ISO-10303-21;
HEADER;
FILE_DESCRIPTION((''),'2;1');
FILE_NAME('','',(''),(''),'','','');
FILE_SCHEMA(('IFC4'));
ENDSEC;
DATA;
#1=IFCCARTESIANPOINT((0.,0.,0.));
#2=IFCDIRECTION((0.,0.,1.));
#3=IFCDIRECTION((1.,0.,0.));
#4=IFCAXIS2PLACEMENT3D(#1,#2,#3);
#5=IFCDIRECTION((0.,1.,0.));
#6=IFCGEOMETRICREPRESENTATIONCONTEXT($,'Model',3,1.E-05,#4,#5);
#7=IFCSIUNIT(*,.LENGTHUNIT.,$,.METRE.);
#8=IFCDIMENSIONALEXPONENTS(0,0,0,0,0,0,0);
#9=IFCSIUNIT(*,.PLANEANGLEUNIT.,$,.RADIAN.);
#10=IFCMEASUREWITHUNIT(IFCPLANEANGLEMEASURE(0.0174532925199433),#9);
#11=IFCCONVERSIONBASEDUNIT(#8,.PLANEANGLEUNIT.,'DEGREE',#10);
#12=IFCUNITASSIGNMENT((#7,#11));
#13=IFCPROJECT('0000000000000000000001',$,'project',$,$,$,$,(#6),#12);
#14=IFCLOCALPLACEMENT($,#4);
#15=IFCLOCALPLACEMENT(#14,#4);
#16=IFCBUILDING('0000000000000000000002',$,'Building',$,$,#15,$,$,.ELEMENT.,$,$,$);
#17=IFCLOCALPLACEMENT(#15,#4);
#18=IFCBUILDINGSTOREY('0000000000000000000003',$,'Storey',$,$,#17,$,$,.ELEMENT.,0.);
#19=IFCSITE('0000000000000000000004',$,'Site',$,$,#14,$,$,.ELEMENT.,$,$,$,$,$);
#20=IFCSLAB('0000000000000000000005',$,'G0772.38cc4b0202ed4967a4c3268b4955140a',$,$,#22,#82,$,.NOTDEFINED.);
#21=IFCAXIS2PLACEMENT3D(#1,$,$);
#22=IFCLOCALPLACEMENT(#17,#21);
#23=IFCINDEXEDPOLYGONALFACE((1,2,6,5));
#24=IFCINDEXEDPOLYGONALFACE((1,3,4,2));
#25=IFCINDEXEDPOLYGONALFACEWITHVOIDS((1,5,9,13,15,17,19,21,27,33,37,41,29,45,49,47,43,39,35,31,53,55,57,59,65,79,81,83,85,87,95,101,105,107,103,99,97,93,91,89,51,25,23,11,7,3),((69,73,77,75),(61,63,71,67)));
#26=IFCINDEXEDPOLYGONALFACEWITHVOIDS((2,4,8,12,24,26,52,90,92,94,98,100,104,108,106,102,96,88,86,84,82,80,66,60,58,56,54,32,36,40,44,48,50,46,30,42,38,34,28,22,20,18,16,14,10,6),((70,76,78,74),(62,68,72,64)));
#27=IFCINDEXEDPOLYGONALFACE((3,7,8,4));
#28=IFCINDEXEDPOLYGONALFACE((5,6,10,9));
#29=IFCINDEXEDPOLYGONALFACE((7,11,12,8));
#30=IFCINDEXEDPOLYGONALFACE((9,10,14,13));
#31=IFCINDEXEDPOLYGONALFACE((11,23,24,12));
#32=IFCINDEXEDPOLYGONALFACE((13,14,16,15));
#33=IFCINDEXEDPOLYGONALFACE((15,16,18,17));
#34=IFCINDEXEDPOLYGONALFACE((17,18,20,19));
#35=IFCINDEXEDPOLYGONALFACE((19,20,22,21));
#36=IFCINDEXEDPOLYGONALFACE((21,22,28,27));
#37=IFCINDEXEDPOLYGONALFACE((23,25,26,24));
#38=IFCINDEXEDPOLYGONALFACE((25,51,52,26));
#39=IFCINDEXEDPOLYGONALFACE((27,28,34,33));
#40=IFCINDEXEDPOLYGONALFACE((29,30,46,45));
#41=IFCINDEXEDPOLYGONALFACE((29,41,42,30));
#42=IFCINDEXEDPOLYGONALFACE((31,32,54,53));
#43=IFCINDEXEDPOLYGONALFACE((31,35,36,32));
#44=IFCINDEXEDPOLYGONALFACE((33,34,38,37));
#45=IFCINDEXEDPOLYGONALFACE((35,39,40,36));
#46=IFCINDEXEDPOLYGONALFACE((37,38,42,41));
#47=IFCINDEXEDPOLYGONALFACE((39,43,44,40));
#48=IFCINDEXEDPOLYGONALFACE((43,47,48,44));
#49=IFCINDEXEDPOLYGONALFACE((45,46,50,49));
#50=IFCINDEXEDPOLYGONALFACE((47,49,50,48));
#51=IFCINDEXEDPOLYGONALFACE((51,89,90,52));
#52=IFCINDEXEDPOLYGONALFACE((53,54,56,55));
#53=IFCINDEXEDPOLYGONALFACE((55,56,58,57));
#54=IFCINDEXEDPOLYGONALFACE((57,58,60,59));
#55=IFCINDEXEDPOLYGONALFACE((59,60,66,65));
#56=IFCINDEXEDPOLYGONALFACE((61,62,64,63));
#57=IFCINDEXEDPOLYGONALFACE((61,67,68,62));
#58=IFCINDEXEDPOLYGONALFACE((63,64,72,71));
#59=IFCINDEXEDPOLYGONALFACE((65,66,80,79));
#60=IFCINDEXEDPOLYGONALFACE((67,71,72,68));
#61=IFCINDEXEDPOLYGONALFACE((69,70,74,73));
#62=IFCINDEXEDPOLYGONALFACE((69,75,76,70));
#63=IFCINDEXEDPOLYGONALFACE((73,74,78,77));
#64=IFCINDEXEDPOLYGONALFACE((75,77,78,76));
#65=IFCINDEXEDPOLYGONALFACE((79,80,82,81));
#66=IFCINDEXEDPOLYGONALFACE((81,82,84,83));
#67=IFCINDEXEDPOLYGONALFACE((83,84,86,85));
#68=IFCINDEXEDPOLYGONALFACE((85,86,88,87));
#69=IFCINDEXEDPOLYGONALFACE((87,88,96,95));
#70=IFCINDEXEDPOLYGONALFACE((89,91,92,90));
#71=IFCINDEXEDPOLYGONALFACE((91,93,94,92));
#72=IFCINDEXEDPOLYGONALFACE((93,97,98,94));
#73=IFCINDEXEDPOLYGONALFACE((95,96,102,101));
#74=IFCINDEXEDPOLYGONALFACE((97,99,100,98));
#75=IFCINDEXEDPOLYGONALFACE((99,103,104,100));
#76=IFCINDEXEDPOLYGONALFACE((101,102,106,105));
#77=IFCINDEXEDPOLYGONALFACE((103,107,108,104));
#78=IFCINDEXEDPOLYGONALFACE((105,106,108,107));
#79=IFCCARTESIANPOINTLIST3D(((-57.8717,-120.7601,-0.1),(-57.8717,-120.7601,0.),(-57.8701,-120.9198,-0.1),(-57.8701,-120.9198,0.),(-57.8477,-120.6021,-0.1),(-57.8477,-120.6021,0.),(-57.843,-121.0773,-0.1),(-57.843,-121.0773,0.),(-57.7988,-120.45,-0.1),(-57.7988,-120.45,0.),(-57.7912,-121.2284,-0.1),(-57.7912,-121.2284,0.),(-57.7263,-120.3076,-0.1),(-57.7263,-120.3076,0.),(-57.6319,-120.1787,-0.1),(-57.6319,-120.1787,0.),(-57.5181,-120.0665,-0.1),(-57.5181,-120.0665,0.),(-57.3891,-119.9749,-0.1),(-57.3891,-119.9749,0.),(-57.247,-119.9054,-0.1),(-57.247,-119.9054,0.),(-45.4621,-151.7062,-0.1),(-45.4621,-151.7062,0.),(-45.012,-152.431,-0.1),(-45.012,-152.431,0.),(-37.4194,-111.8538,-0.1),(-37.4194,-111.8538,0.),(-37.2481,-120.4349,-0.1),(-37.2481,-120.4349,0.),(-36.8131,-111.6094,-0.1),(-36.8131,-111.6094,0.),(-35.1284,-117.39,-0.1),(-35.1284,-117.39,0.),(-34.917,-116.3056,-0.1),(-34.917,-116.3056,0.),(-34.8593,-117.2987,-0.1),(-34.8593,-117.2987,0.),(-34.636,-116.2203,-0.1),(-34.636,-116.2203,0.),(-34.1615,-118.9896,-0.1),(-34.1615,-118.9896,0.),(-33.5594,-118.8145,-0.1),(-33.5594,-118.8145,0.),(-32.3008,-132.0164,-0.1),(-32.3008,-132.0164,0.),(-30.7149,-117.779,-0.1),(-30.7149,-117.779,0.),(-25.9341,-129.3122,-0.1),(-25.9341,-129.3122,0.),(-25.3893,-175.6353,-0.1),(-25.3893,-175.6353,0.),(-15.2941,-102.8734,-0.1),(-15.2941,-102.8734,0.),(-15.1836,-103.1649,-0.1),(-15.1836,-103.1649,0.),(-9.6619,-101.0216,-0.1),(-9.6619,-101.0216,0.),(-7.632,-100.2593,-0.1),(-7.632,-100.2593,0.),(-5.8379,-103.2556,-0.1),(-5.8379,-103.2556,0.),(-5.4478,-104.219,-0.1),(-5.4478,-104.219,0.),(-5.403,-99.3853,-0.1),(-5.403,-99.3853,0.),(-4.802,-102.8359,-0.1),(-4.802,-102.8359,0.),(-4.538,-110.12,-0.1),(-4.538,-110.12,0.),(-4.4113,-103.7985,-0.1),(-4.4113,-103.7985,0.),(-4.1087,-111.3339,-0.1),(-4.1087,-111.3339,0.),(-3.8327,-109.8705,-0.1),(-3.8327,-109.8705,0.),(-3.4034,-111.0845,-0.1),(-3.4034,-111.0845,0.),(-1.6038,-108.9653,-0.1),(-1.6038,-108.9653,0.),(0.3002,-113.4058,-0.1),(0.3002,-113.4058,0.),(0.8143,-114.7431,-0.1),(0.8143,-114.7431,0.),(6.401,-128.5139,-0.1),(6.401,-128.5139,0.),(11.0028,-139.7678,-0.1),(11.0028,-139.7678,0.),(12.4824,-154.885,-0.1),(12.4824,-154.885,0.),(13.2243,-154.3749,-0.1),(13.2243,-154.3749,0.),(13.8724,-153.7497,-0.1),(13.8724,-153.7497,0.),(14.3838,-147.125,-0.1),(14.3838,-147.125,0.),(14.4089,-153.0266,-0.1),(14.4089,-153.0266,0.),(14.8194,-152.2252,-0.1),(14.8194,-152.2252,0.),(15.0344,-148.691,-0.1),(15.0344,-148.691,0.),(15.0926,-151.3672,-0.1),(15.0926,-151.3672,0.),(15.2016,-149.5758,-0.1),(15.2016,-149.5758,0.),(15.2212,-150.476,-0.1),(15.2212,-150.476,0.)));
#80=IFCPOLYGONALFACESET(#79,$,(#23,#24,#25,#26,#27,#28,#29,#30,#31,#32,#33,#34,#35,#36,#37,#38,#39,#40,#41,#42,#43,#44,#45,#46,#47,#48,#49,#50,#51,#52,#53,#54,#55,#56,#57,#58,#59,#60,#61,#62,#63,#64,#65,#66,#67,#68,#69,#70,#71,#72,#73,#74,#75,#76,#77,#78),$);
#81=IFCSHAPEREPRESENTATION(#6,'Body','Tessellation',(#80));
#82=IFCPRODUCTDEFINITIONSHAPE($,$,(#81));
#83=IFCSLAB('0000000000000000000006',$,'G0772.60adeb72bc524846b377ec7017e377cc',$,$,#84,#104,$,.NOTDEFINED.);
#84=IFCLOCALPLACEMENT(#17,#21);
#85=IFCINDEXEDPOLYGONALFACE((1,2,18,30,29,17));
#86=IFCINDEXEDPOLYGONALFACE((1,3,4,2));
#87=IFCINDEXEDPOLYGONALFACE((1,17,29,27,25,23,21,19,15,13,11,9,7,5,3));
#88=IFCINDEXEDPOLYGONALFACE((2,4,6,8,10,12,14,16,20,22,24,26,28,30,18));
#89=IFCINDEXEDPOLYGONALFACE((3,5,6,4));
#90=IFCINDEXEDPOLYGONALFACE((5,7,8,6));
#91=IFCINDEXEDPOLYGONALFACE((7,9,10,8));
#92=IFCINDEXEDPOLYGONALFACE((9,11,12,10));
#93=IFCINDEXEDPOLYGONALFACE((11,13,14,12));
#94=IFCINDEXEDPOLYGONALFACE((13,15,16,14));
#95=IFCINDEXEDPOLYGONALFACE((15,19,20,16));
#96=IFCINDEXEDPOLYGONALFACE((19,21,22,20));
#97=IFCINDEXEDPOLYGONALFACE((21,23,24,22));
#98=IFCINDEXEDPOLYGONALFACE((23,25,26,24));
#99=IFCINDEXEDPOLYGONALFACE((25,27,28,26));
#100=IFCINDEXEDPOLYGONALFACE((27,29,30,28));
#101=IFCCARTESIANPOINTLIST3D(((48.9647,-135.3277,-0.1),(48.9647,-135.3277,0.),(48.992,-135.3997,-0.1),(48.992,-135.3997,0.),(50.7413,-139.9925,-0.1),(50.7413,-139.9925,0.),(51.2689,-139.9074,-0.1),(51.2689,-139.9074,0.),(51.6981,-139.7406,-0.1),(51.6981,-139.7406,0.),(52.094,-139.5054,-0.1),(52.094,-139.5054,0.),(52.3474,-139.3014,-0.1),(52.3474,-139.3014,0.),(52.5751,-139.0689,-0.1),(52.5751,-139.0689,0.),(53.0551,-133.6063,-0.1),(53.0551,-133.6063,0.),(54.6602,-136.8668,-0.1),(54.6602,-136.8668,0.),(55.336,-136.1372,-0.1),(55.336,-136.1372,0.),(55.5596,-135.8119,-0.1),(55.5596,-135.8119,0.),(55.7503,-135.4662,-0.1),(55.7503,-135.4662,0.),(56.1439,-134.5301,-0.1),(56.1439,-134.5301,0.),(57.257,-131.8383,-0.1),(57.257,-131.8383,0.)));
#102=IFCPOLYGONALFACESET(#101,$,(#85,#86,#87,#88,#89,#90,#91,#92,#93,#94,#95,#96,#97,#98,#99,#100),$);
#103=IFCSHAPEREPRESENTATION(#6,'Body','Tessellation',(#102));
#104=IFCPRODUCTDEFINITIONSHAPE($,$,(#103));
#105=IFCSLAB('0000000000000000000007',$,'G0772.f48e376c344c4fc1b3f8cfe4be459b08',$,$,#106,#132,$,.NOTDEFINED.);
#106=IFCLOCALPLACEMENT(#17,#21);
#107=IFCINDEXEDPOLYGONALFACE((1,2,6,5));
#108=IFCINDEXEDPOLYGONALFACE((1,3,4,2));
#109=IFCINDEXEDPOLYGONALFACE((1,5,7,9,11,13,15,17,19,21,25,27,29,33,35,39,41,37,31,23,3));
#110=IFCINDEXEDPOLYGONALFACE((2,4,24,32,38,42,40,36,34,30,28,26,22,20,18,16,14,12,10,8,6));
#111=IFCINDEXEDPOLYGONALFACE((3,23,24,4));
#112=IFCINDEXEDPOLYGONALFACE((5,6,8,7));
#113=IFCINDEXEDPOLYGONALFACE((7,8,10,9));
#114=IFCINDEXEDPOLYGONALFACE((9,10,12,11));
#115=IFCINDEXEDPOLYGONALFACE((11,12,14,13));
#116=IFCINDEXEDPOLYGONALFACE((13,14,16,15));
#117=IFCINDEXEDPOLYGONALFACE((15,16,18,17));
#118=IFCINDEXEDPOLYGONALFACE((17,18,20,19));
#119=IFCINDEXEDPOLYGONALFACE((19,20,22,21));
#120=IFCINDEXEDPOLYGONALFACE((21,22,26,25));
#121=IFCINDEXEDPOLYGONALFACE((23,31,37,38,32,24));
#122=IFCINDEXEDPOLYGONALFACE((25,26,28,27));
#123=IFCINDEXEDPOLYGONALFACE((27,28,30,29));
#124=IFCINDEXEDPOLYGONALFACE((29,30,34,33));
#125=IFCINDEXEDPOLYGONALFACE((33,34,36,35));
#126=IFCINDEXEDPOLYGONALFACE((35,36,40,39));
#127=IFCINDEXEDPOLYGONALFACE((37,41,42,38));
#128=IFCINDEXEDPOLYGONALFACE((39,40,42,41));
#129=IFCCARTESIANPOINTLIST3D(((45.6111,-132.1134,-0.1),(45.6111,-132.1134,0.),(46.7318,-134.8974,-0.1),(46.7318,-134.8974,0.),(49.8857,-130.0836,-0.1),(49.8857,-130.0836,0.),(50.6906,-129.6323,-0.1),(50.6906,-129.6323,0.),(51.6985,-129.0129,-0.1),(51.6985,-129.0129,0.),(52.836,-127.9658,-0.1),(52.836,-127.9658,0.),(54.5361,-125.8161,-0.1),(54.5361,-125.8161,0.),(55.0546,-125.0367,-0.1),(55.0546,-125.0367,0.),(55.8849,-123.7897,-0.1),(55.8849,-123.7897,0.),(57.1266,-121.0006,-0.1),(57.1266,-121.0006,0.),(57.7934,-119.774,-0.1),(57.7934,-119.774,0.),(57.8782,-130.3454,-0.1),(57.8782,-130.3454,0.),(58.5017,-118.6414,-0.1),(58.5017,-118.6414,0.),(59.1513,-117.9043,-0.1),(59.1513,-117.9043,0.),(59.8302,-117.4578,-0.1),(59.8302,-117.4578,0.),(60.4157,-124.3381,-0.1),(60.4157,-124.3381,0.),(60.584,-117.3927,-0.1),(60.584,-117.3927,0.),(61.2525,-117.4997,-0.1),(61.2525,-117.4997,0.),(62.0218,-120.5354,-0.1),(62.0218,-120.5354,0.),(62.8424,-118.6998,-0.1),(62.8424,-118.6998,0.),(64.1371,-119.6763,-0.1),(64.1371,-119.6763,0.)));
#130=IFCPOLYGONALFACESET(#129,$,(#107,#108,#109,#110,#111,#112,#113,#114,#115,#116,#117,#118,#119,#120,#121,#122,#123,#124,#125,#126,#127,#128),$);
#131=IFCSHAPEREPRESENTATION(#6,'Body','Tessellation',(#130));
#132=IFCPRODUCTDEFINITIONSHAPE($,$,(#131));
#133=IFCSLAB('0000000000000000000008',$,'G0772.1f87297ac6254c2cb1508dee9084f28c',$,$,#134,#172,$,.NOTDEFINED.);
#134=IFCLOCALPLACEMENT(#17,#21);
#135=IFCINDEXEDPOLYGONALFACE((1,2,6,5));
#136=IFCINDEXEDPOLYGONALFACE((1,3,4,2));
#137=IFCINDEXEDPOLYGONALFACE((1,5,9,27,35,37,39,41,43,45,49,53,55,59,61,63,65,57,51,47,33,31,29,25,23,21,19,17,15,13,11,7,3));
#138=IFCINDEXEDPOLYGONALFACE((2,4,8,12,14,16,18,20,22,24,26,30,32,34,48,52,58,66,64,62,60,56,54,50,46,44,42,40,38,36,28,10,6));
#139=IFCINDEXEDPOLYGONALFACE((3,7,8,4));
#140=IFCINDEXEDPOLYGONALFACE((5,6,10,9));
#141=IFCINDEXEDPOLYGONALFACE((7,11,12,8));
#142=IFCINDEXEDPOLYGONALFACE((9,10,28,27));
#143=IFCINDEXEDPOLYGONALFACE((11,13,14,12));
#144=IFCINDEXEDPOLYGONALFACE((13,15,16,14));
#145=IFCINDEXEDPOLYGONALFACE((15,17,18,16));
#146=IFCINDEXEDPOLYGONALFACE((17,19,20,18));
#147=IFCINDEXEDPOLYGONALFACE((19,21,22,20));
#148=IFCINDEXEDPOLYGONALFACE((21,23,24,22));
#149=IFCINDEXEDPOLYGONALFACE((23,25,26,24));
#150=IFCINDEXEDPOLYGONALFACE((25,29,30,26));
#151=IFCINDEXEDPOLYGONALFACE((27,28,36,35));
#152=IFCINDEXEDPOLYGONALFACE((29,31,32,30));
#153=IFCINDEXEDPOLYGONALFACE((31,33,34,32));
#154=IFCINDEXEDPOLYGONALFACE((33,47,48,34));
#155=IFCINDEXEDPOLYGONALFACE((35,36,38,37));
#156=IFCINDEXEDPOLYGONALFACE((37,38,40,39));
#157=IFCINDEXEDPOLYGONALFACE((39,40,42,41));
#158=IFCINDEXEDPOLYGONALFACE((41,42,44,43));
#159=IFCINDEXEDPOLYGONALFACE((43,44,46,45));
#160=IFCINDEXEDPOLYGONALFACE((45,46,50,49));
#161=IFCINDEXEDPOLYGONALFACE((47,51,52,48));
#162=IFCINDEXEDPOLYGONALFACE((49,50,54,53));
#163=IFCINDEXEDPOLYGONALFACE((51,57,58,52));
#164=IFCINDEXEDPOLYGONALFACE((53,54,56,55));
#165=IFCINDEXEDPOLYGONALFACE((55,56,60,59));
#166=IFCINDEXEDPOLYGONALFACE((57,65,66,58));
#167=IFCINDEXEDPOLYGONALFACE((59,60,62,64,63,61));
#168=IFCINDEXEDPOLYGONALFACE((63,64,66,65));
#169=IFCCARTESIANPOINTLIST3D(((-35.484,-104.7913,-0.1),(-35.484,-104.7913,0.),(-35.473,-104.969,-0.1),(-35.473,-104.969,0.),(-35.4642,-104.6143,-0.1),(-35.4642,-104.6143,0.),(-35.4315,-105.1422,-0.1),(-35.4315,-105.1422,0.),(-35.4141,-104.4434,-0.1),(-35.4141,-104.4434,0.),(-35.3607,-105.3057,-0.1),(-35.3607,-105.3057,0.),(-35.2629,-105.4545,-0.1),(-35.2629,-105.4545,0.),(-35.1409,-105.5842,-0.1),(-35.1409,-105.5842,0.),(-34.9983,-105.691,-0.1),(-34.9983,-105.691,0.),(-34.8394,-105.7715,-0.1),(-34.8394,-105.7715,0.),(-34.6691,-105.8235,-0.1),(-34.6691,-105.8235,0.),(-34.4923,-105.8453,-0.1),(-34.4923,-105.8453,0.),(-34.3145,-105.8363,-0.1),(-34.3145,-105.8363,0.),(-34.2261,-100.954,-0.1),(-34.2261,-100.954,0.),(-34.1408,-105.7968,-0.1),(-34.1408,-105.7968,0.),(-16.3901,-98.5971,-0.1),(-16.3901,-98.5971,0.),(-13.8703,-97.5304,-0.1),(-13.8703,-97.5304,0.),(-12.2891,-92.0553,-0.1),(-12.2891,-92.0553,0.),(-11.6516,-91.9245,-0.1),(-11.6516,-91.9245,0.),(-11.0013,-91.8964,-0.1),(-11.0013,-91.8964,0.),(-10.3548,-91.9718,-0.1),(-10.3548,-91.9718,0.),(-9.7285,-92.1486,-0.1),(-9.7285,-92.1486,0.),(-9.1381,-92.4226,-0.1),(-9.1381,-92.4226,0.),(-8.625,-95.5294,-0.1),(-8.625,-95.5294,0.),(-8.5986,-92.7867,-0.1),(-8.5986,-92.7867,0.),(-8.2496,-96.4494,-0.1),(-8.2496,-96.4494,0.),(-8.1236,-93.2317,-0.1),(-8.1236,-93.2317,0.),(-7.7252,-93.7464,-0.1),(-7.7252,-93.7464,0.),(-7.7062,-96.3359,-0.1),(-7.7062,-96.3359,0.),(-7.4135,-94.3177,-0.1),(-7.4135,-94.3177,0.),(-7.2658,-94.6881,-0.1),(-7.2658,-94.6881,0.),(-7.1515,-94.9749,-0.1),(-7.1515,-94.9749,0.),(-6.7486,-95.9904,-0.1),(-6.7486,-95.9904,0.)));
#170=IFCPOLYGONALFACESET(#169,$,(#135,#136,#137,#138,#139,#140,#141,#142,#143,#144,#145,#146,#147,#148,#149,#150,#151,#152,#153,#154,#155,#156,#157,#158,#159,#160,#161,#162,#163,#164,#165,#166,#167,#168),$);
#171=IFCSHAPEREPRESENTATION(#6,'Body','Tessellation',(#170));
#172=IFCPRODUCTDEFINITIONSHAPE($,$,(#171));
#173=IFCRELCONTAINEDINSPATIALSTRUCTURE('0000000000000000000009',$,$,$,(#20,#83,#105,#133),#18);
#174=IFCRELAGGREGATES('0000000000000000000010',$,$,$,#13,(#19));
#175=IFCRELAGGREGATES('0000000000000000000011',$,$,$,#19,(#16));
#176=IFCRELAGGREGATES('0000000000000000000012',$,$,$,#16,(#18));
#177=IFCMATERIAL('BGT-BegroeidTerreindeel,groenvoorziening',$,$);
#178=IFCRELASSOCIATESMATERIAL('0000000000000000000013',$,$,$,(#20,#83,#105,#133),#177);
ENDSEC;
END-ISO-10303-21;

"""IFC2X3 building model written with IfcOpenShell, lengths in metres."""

from ifc_helpers import new_model, entity, si_unit, converted_unit, direction, frame, origin_with_axes, place, context, project, spatial, polyline, outline, extrude, material, element, save


model = new_model("IFC2X3")

# Units and contexts
model_context = context("Model", 3, precision=1e-05, world=origin_with_axes(), true_north=direction((0.0, 1.0, 0.0)))
ifc_project = project(units=[si_unit("LENGTHUNIT", "METRE"), converted_unit("PLANEANGLEUNIT", "DEGREE", entity("IfcPlaneAngleMeasure", 0.0174532925199433), si_unit("PLANEANGLEUNIT", "RADIAN"), dimensions=[0, 0, 0, 0, 0, 0, 0])], contexts=[model_context])

# Site, building, storey
site_placement = place(None, origin_with_axes())
site = spatial("IfcSite", under=ifc_project, at=site_placement, Name="Site", CompositionType="ELEMENT")
building_placement = place(site_placement, origin_with_axes())
building = spatial("IfcBuilding", under=site, at=building_placement, Name="Building", CompositionType="ELEMENT")
storey_placement = place(building_placement, origin_with_axes())
storey = spatial("IfcBuildingStorey", under=building, at=storey_placement, Name="Storey", CompositionType="ELEMENT", Elevation=0.0)

# Slabs
ifc_material_1 = material(Name="BGT-BegroeidTerreindeel,groenvoorziening")
slab_1_placement = place(storey_placement, frame((0.0, 0.0, -0.1), z_axis=(0.0, 0.0, 1.0), x_axis=(1.0, 0.0, 0.0)))
element("IfcSlab", 1, at=slab_1_placement, inside=storey, material=ifc_material_1, Name="G0772.38cc4b0202ed4967a4c3268b4955140a", PredefinedType="NOTDEFINED", context=model_context, shape_type="SweptSolid", body=[
    extrude(outline(polyline([(-1.6038, -108.9653), (0.3002, -113.4058), (0.8143, -114.7431), (6.401, -128.5139), (11.0028, -139.7678), (14.3838, -147.125), (15.0344, -148.691), (15.2016, -149.5758), (15.2212, -150.476), (15.0926, -151.3672), (14.8194, -152.2252), (14.4089, -153.0266), (13.8724, -153.7497), (13.2243, -154.3749), (12.4824, -154.885), (-25.3893, -175.6353), (-45.012, -152.431), (-45.4621, -151.7062), (-57.7912, -121.2284), (-57.843, -121.0773), (-57.8701, -120.9198), (-57.8717, -120.7601), (-57.8477, -120.6021), (-57.7988, -120.45), (-57.7263, -120.3076), (-57.6319, -120.1787), (-57.5181, -120.0665), (-57.3891, -119.9749), (-57.247, -119.9054), (-37.4194, -111.8538), (-35.1284, -117.39), (-34.8593, -117.2987), (-34.1615, -118.9896), (-37.2481, -120.4349), (-32.3008, -132.0164), (-25.9341, -129.3122), (-30.7149, -117.779), (-33.5594, -118.8145), (-34.636, -116.2203), (-34.917, -116.3056), (-36.8131, -111.6094), (-15.2941, -102.8734), (-15.1836, -103.1649), (-9.6619, -101.0216), (-7.632, -100.2593), (-5.403, -99.3853), (-1.6038, -108.9653)]), holes=[polyline([(-4.1087, -111.3339), (-3.4034, -111.0845), (-3.8327, -109.8705), (-4.538, -110.12), (-4.1087, -111.3339)]), polyline([(-5.4478, -104.219), (-4.4113, -103.7985), (-4.802, -102.8359), (-5.8379, -103.2556), (-5.4478, -104.219)])]), origin_with_axes(), (0.0, 0.0, 1.0), 0.1),
])
slab_2_placement = place(storey_placement, frame((0.0, 0.0, -0.1), z_axis=(0.0, 0.0, 1.0), x_axis=(1.0, 0.0, 0.0)))
element("IfcSlab", 2, at=slab_2_placement, inside=storey, material=ifc_material_1, Name="G0772.60adeb72bc524846b377ec7017e377cc", PredefinedType="NOTDEFINED", context=model_context, shape_type="SweptSolid", body=[
    extrude(outline(polyline([(48.9647, -135.3277), (53.0551, -133.6063), (57.257, -131.8383), (56.1439, -134.5301), (55.7503, -135.4662), (55.5596, -135.8119), (55.336, -136.1372), (54.6602, -136.8668), (52.5751, -139.0689), (52.3474, -139.3014), (52.094, -139.5054), (51.6981, -139.7406), (51.2689, -139.9074), (50.7413, -139.9925), (48.992, -135.3997), (48.9647, -135.3277)])), origin_with_axes(), (0.0, 0.0, 1.0), 0.1),
])
slab_3_placement = place(storey_placement, frame((0.0, 0.0, -0.1), z_axis=(0.0, 0.0, 1.0), x_axis=(1.0, 0.0, 0.0)))
element("IfcSlab", 3, at=slab_3_placement, inside=storey, material=ifc_material_1, Name="G0772.f48e376c344c4fc1b3f8cfe4be459b08", PredefinedType="NOTDEFINED", context=model_context, shape_type="SweptSolid", body=[
    extrude(outline(polyline([(62.8424, -118.6998), (64.1371, -119.6763), (62.0218, -120.5354), (60.4157, -124.3381), (57.8782, -130.3454), (46.7318, -134.8974), (45.6111, -132.1134), (49.8857, -130.0836), (50.6906, -129.6323), (51.6985, -129.0129), (52.836, -127.9658), (54.5361, -125.8161), (55.0546, -125.0367), (55.8849, -123.7897), (57.1266, -121.0006), (57.7934, -119.774), (58.5017, -118.6414), (59.1513, -117.9043), (59.8302, -117.4578), (60.584, -117.3927), (61.2525, -117.4997), (62.8424, -118.6998)])), origin_with_axes(), (0.0, 0.0, 1.0), 0.1),
])
slab_4_placement = place(storey_placement, frame((0.0, 0.0, -0.1), z_axis=(0.0, 0.0, 1.0), x_axis=(1.0, 0.0, 0.0)))
element("IfcSlab", 4, at=slab_4_placement, inside=storey, material=ifc_material_1, Name="G0772.1f87297ac6254c2cb1508dee9084f28c", PredefinedType="NOTDEFINED", context=model_context, shape_type="SweptSolid", body=[
    extrude(outline(polyline([(-12.2891, -92.0553), (-11.6516, -91.9245), (-11.0013, -91.8964), (-10.3548, -91.9718), (-9.7285, -92.1486), (-9.1381, -92.4226), (-8.5986, -92.7867), (-8.1236, -93.2317), (-7.7252, -93.7464), (-7.4135, -94.3177), (-7.2658, -94.6881), (-7.1515, -94.9749), (-6.7486, -95.9904), (-7.7062, -96.3359), (-8.2496, -96.4494), (-8.625, -95.5294), (-13.8703, -97.5304), (-16.3901, -98.5971), (-34.1408, -105.7968), (-34.3145, -105.8363), (-34.4923, -105.8453), (-34.6691, -105.8235), (-34.8394, -105.7715), (-34.9983, -105.691), (-35.1409, -105.5842), (-35.2629, -105.4545), (-35.3607, -105.3057), (-35.4315, -105.1422), (-35.473, -104.969), (-35.484, -104.7913), (-35.4642, -104.6143), (-35.4141, -104.4434), (-34.2261, -100.954), (-12.2891, -92.0553)])), origin_with_axes(), (0.0, 0.0, 1.0), 0.1),
])

save(model, "model.ifc")
